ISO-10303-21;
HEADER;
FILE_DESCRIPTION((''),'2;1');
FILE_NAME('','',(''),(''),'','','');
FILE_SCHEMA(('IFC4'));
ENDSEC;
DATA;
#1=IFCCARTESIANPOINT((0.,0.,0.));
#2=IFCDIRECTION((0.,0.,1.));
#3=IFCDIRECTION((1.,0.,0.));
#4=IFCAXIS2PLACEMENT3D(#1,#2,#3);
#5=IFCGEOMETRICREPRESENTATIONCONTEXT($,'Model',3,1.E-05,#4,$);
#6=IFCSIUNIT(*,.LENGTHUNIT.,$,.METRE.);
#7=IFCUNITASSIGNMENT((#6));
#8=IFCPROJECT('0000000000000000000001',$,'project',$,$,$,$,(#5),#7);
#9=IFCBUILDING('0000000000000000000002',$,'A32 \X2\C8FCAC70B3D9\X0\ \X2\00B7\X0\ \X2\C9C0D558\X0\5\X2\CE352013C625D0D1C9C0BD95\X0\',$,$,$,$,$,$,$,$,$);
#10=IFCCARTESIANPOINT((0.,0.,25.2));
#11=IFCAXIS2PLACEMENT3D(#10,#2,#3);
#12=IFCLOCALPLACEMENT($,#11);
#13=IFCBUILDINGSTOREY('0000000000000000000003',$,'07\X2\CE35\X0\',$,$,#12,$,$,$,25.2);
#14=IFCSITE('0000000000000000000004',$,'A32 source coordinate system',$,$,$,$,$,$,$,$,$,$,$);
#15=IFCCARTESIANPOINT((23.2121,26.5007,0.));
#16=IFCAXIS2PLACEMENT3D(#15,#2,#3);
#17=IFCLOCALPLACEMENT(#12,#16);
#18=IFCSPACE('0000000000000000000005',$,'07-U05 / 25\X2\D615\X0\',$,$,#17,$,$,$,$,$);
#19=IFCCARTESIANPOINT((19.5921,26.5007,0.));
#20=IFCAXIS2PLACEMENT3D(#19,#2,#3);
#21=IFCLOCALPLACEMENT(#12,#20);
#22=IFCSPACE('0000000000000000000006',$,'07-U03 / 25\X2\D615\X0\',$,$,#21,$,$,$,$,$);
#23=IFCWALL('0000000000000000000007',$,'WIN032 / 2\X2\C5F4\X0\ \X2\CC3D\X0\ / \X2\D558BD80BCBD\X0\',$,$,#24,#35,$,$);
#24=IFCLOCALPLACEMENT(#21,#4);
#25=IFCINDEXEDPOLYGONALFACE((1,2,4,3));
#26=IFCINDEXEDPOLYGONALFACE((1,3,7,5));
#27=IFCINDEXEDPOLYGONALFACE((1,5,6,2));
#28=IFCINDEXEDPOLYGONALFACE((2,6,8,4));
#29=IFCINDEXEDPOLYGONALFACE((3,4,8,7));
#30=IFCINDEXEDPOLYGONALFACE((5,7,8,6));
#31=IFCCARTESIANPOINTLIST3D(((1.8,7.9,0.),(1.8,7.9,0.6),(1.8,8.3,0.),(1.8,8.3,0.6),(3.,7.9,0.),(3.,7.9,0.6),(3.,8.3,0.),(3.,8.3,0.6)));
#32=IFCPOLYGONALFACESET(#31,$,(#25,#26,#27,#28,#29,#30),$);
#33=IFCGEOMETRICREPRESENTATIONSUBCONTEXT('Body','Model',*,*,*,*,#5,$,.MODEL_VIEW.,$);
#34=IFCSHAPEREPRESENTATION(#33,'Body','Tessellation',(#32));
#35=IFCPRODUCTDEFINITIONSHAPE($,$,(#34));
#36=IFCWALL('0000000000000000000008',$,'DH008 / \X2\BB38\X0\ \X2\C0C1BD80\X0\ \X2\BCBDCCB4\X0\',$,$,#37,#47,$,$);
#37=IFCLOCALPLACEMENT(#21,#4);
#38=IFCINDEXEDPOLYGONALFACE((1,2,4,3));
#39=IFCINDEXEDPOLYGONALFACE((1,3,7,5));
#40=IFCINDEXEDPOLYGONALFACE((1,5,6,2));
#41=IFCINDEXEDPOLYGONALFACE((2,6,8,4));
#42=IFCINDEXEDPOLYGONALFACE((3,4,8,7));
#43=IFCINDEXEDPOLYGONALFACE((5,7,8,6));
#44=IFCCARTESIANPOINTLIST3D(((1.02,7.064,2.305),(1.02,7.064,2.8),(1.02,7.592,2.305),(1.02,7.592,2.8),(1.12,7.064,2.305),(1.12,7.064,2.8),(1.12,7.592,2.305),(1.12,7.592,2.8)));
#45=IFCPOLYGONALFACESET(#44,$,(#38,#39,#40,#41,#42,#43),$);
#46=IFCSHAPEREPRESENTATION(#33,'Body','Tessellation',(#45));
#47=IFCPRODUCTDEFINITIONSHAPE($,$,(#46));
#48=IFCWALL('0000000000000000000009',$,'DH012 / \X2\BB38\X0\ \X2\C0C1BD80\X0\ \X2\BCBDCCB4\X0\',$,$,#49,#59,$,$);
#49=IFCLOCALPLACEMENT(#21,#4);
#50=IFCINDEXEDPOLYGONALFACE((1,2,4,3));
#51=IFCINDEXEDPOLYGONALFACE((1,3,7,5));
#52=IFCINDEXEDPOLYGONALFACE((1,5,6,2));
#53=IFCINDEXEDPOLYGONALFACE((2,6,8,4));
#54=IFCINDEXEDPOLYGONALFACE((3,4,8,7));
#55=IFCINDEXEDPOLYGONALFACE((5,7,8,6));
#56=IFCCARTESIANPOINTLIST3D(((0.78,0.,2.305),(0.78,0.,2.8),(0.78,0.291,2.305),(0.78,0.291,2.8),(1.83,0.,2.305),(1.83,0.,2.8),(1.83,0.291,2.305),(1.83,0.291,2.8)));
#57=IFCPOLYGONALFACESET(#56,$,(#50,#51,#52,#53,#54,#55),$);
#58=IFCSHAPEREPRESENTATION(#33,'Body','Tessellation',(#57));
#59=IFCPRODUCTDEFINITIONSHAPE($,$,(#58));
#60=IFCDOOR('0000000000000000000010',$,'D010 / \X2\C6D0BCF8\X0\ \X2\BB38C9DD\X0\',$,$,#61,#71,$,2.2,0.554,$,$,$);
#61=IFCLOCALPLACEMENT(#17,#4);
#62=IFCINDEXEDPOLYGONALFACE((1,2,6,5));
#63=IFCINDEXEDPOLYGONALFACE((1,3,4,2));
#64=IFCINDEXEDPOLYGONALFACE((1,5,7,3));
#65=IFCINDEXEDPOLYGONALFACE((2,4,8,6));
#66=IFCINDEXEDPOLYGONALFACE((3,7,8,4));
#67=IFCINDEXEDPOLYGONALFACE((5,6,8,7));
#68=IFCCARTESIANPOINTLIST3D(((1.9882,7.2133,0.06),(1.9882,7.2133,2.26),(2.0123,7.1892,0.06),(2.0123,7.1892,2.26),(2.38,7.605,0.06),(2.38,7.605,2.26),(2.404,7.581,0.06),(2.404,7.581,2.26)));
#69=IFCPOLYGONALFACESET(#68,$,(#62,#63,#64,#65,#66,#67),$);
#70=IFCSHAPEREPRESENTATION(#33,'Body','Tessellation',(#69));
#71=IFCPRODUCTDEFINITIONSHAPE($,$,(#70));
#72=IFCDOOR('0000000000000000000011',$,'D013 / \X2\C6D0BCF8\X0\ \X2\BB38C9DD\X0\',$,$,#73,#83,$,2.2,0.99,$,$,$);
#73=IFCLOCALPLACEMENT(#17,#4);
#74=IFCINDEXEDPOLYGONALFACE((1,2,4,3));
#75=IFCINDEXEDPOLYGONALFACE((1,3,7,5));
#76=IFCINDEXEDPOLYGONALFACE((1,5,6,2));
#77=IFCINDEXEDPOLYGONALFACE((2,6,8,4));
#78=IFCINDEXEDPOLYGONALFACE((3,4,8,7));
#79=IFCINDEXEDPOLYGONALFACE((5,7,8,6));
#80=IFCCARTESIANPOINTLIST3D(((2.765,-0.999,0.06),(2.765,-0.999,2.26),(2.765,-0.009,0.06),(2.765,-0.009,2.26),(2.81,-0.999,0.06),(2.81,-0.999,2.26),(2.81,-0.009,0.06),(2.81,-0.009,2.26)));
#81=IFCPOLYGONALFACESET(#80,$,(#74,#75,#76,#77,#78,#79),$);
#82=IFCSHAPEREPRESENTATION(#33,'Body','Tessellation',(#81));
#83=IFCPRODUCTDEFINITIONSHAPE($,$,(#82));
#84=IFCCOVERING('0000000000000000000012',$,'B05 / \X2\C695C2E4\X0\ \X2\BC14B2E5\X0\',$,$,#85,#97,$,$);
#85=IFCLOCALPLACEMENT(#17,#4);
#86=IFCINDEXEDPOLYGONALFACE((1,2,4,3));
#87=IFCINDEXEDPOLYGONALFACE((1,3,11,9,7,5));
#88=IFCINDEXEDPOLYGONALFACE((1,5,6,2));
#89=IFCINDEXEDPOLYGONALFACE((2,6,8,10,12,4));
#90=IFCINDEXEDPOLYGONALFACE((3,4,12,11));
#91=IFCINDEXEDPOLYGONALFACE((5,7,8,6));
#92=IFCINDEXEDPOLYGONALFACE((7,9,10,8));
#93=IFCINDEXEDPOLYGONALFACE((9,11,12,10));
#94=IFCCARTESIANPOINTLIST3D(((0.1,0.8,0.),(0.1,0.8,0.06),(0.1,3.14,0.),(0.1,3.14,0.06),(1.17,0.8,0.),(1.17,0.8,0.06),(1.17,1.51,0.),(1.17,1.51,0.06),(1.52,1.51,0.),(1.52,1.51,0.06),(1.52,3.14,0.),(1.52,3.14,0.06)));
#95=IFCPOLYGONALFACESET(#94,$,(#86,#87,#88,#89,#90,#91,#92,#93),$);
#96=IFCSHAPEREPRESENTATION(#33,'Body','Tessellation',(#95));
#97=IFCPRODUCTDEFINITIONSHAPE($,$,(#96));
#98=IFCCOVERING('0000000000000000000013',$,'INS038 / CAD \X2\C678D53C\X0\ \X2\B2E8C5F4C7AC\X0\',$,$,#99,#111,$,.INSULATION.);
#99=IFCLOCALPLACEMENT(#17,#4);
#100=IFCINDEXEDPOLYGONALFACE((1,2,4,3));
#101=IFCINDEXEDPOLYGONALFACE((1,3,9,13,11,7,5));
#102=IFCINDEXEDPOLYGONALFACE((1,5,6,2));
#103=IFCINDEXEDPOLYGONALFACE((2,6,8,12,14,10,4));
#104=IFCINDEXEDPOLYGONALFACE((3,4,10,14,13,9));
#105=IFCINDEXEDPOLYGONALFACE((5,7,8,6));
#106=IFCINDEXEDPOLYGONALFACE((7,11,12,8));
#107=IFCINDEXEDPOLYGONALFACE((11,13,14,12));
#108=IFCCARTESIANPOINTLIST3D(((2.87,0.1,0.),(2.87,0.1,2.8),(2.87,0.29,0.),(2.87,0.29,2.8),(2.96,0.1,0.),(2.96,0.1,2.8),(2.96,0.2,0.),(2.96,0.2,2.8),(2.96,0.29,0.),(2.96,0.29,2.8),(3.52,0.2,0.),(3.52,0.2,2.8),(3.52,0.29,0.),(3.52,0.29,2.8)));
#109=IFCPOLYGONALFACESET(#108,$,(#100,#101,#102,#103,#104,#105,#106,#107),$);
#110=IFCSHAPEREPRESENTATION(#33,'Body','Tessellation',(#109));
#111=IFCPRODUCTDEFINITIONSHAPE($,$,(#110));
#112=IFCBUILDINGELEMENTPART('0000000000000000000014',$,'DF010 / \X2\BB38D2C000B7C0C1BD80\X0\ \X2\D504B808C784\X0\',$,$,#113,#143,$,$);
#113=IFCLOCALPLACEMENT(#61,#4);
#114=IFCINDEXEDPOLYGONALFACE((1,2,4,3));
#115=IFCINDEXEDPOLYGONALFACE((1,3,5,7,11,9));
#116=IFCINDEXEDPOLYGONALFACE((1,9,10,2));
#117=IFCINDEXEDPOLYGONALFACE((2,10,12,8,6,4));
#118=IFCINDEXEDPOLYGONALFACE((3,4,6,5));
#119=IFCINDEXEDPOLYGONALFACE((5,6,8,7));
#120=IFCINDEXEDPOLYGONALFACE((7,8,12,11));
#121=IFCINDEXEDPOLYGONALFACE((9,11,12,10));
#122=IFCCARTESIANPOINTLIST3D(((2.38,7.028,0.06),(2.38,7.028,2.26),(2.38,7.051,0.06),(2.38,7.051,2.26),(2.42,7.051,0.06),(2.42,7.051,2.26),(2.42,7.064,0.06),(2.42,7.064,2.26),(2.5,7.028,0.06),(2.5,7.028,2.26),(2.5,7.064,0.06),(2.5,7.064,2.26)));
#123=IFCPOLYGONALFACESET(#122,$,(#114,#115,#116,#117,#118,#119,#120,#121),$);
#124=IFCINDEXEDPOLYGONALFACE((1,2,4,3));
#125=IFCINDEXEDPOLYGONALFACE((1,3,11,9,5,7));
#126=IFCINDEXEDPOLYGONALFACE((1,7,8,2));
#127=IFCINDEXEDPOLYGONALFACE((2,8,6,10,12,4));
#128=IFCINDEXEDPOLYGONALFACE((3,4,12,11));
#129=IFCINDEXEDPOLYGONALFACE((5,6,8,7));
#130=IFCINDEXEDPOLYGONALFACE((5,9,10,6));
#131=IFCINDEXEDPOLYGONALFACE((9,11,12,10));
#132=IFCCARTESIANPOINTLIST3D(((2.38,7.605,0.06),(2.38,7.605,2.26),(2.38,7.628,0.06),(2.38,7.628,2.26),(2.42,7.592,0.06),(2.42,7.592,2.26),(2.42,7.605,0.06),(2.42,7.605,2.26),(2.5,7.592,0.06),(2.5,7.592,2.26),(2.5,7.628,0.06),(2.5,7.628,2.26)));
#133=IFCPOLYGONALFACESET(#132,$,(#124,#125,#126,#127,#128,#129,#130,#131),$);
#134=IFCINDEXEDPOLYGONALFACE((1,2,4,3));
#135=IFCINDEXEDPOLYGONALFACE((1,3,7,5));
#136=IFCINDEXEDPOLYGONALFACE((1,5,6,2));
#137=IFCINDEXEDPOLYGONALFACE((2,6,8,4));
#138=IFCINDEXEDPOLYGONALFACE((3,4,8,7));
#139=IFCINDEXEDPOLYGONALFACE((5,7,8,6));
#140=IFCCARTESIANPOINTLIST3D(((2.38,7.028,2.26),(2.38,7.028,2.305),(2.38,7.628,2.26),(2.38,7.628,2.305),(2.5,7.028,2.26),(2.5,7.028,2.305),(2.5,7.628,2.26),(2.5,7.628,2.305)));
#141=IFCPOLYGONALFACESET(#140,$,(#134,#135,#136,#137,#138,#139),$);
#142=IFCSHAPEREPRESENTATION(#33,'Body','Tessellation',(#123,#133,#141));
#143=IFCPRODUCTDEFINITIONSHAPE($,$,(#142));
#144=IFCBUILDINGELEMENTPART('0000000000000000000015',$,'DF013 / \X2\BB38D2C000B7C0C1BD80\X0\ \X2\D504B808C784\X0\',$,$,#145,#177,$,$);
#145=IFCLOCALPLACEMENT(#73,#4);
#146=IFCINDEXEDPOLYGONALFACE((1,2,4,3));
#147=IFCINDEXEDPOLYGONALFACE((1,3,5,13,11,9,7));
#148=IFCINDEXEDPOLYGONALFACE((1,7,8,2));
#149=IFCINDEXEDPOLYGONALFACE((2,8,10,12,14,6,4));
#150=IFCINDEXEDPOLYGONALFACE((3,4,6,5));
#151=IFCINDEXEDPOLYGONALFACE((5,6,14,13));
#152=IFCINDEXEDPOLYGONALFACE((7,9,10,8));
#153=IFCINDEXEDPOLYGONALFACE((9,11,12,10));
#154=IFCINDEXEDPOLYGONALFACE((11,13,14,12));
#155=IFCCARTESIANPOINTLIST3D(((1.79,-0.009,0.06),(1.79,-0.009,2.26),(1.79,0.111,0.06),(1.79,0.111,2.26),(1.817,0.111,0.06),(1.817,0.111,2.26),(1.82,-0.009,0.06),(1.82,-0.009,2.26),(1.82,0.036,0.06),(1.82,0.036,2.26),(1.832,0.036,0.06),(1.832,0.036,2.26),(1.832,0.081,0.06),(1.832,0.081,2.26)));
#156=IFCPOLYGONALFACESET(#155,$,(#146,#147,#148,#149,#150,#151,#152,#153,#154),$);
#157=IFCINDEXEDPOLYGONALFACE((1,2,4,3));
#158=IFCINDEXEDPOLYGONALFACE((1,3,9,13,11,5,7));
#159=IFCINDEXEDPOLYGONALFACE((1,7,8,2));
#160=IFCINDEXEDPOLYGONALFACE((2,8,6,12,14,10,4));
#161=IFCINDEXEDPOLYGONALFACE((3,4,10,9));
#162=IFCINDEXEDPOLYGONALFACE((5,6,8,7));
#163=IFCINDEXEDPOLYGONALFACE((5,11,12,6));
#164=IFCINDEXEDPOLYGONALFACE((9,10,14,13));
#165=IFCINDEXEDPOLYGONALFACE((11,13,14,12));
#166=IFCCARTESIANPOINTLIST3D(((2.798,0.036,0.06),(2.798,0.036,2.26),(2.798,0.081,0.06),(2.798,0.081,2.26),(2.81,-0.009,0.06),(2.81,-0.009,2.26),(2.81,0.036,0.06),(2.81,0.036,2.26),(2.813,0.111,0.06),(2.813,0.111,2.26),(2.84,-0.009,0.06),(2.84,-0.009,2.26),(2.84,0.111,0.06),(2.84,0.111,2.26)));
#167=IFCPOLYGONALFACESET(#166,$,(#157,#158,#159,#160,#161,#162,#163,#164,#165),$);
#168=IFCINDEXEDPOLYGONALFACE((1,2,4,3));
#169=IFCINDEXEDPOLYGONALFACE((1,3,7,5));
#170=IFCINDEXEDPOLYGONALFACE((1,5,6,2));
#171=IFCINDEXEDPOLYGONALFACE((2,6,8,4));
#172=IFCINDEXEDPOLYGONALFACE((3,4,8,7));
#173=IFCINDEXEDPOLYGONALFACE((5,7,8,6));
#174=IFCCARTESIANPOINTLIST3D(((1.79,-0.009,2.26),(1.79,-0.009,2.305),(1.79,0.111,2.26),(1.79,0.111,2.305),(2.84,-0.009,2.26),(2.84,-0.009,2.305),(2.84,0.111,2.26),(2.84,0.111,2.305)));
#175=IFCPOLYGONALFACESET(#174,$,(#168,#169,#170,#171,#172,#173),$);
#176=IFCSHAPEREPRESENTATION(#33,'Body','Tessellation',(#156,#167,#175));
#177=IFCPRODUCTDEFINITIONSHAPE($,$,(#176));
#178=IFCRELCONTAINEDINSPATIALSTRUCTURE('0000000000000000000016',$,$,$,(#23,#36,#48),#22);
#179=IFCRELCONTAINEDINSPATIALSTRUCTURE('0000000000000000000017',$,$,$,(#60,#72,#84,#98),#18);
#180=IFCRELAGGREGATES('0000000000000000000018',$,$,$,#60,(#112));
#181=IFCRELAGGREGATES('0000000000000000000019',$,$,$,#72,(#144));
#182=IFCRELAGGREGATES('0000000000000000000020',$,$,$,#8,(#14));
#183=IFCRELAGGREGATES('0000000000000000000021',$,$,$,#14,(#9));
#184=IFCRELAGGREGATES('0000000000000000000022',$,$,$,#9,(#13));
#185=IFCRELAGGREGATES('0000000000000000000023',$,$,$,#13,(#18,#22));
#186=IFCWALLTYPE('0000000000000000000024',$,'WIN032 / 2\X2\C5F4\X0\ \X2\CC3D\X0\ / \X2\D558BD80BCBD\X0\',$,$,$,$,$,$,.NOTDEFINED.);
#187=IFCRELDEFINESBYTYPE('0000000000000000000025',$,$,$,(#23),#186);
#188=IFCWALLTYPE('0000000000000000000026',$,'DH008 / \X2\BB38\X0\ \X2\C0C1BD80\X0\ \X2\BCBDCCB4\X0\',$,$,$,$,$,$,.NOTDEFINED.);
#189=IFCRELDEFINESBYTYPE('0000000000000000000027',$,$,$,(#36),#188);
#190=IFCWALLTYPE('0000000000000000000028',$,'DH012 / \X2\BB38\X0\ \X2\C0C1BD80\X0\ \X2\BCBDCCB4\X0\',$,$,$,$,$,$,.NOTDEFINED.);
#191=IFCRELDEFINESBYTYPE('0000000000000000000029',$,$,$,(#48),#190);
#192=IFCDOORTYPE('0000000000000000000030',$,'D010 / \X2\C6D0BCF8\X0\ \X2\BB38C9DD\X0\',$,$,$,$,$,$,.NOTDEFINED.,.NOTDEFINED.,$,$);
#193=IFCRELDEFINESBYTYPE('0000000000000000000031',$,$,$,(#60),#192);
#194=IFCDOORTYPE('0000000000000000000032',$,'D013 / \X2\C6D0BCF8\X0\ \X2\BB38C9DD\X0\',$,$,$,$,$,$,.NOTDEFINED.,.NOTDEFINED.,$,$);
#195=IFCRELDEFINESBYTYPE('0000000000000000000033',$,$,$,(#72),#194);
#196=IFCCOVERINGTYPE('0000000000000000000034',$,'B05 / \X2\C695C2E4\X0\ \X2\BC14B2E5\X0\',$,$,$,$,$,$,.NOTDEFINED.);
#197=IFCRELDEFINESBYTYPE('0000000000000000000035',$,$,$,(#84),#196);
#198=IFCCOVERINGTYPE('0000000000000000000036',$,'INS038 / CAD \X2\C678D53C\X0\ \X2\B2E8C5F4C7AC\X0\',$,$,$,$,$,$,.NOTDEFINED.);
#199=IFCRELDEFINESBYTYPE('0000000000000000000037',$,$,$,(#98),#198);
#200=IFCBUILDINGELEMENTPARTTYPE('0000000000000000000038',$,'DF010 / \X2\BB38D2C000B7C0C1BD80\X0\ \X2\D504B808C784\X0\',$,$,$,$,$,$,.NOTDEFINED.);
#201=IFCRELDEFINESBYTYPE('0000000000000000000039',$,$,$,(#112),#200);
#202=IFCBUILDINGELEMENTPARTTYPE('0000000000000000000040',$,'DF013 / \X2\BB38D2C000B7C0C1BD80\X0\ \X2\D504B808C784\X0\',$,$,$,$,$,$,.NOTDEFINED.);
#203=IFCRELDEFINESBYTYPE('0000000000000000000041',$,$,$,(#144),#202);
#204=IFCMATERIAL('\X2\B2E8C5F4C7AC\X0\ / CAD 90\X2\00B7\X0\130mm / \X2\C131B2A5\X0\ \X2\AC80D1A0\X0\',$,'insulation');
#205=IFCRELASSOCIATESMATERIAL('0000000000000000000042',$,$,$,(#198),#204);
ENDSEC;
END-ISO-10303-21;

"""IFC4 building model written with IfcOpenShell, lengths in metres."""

from ifc_helpers import new_model, si_unit, frame, origin, origin_with_axes, place, context, subcontext, project, spatial, polyline, outline, extrude, source, transform, mapped, material, type_object, type_shapes, element, aggregate, save


model = new_model("IFC4")

# Units and contexts
model_context = context("Model", 3, precision=1e-05, world=origin_with_axes())
body_context = subcontext(model_context, "Body", "Model", "MODEL_VIEW")
ifc_project = project(units=[si_unit("LENGTHUNIT", "METRE")], contexts=[model_context])

# Site, building, storey, space
storey_placement = place(None, frame((0.0, 0.0, 25.2), z_axis=(0.0, 0.0, 1.0), x_axis=(1.0, 0.0, 0.0)))
space_1_placement = place(storey_placement, frame((23.2121, 26.5007, 0.0), z_axis=(0.0, 0.0, 1.0), x_axis=(1.0, 0.0, 0.0)))
site = spatial("IfcSite", under=ifc_project, Name="A32 source coordinate system")
building = spatial("IfcBuilding", under=site, Name="A32 주거동 · 지하5층–옥탑지붕")
storey = spatial("IfcBuildingStorey", under=building, at=storey_placement, Name="07층", Elevation=25.2)
space_1 = spatial("IfcSpace", under=storey, at=space_1_placement, Name="07-U05 / 25형")

# Shared definitions
space_2_placement = place(storey_placement, frame((19.5921, 26.5007, 0.0), z_axis=(0.0, 0.0, 1.0), x_axis=(1.0, 0.0, 0.0)))
space_2 = spatial("IfcSpace", under=storey, at=space_2_placement, Name="07-U03 / 25형")

# Walls
wall_type_1 = type_object("IfcWallType", Name="WIN032 / 2열 창 / 하부벽", PredefinedType="NOTDEFINED")
shared_shape_1 = source(origin(), body_context, "Body", "SweptSolid", [
    extrude(outline(polyline([(3.0, 7.9), (1.8, 7.9), (1.8, 8.3), (3.0, 8.3), (3.0, 7.9)])), origin(), (0.0, 0.0, 1.0), 0.6),
])
type_shapes(wall_type_1, [shared_shape_1])
wall_1_placement = place(space_2_placement, origin_with_axes())
element("IfcWall", 1, at=wall_1_placement, inside=space_2, type_object=wall_type_1, Name="WIN032 / 2열 창 / 하부벽", context=body_context, shape_type="MappedRepresentation", body=[
    mapped(shared_shape_1, transform((0.0, 0.0, 0.0), scale=1.0)),
])
wall_type_2 = type_object("IfcWallType", Name="DH008 / 문 상부 벽체", PredefinedType="NOTDEFINED")
shared_shape_2 = source(origin(), body_context, "Body", "SweptSolid", [
    extrude(outline(polyline([(1.12, 7.064), (1.02, 7.064), (1.02, 7.592), (1.12, 7.592), (1.12, 7.064)])), frame((0.0, 0.0, 2.305)), (0.0, 0.0, 1.0), 0.495),
])
type_shapes(wall_type_2, [shared_shape_2])
wall_2_placement = place(space_2_placement, origin_with_axes())
element("IfcWall", 2, at=wall_2_placement, inside=space_2, type_object=wall_type_2, Name="DH008 / 문 상부 벽체", context=body_context, shape_type="MappedRepresentation", body=[
    mapped(shared_shape_2, transform((0.0, 0.0, 0.0), scale=1.0)),
])
wall_type_3 = type_object("IfcWallType", Name="DH012 / 문 상부 벽체", PredefinedType="NOTDEFINED")
shared_shape_3 = source(origin(), body_context, "Body", "SweptSolid", [
    extrude(outline(polyline([(0.78, 0.0), (0.78, 0.291), (1.83, 0.291), (1.83, 0.0), (0.78, 0.0)])), frame((0.0, 0.0, 2.305)), (0.0, 0.0, 1.0), 0.495),
])
type_shapes(wall_type_3, [shared_shape_3])
wall_3_placement = place(space_2_placement, origin_with_axes())
element("IfcWall", 3, at=wall_3_placement, inside=space_2, type_object=wall_type_3, Name="DH012 / 문 상부 벽체", context=body_context, shape_type="MappedRepresentation", body=[
    mapped(shared_shape_3, transform((0.0, 0.0, 0.0), scale=1.0)),
])

# Doors
door_type_1 = type_object("IfcDoorType", Name="D010 / 원본 문짝", OperationType="NOTDEFINED", PredefinedType="NOTDEFINED")
shared_shape_4 = source(origin(), body_context, "Body", "SweptSolid", [
    extrude(outline(polyline([(2.0123, 7.1892), (1.9882, 7.2133), (2.38, 7.605), (2.404, 7.581), (2.0123, 7.1892)])), frame((0.0, 0.0, 0.06)), (0.0, 0.0, 1.0), 2.2),
])
type_shapes(door_type_1, [shared_shape_4])
door_1_placement = place(space_1_placement, origin_with_axes())
door_1 = element("IfcDoor", 4, at=door_1_placement, inside=space_1, type_object=door_type_1, Name="D010 / 원본 문짝", OverallHeight=2.2, OverallWidth=0.554, context=body_context, shape_type="MappedRepresentation", body=[
    mapped(shared_shape_4, transform((0.0, 0.0, 0.0), scale=1.0)),
])
door_type_2 = type_object("IfcDoorType", Name="D013 / 원본 문짝", OperationType="NOTDEFINED", PredefinedType="NOTDEFINED")
shared_shape_5 = source(origin(), body_context, "Body", "SweptSolid", [
    extrude(outline(polyline([(2.81, -0.009), (2.81, -0.999), (2.765, -0.999), (2.765, -0.009), (2.81, -0.009)])), frame((0.0, 0.0, 0.06)), (0.0, 0.0, 1.0), 2.2),
])
type_shapes(door_type_2, [shared_shape_5])
door_2_placement = place(space_1_placement, origin_with_axes())
door_2 = element("IfcDoor", 5, at=door_2_placement, inside=space_1, type_object=door_type_2, Name="D013 / 원본 문짝", OverallHeight=2.2, OverallWidth=0.99, context=body_context, shape_type="MappedRepresentation", body=[
    mapped(shared_shape_5, transform((0.0, 0.0, 0.0), scale=1.0)),
])

# Coverings
covering_type_1 = type_object("IfcCoveringType", Name="B05 / 욕실 바닥", PredefinedType="NOTDEFINED")
shared_shape_6 = source(origin(), body_context, "Body", "SweptSolid", [
    extrude(outline(polyline([(0.1, 3.14), (1.52, 3.14), (1.52, 1.51), (1.17, 1.51), (1.17, 0.8), (0.1, 0.8), (0.1, 3.14)])), origin(), (0.0, 0.0, 1.0), 0.06),
])
type_shapes(covering_type_1, [shared_shape_6])
covering_1_placement = place(space_1_placement, origin_with_axes())
element("IfcCovering", 6, at=covering_1_placement, inside=space_1, type_object=covering_type_1, Name="B05 / 욕실 바닥", context=body_context, shape_type="MappedRepresentation", body=[
    mapped(shared_shape_6, transform((0.0, 0.0, 0.0), scale=1.0)),
])
ifc_material = material(Name="단열재 / CAD 90·130mm / 성능 검토", Category="insulation")
covering_type_2 = type_object("IfcCoveringType", Name="INS038 / CAD 외피 단열재", PredefinedType="NOTDEFINED", material=ifc_material)
shared_shape_7 = source(origin(), body_context, "Body", "SweptSolid", [
    extrude(outline(polyline([(2.96, 0.2), (2.96, 0.1), (2.87, 0.1), (2.87, 0.29), (2.96, 0.29), (3.52, 0.29), (3.52, 0.2), (2.96, 0.2)])), origin(), (0.0, 0.0, 1.0), 2.8),
])
type_shapes(covering_type_2, [shared_shape_7])
covering_2_placement = place(space_1_placement, origin_with_axes())
element("IfcCovering", 7, at=covering_2_placement, inside=space_1, type_object=covering_type_2, Name="INS038 / CAD 외피 단열재", PredefinedType="INSULATION", context=body_context, shape_type="MappedRepresentation", body=[
    mapped(shared_shape_7, transform((0.0, 0.0, 0.0), scale=1.0)),
])

# Building element parts
building_element_part_type_1 = type_object("IfcBuildingElementPartType", Name="DF010 / 문틀·상부 프레임", PredefinedType="NOTDEFINED")
shared_shape_8 = source(origin(), body_context, "Body", "SweptSolid", [
    extrude(outline(polyline([(2.38, 7.028), (2.38, 7.051), (2.42, 7.051), (2.42, 7.064), (2.5, 7.064), (2.5, 7.028), (2.38, 7.028)])), frame((0.0, 0.0, 0.06)), (0.0, 0.0, 1.0), 2.2),
    extrude(outline(polyline([(2.5, 7.592), (2.42, 7.592), (2.42, 7.605), (2.38, 7.605), (2.38, 7.628), (2.5, 7.628), (2.5, 7.592)])), frame((0.0, 0.0, 0.06)), (0.0, 0.0, 1.0), 2.2),
    extrude(outline(polyline([(2.38, 7.028), (2.38, 7.628), (2.5, 7.628), (2.5, 7.028), (2.38, 7.028)])), frame((0.0, 0.0, 2.26)), (0.0, 0.0, 1.0), 0.045),
])
type_shapes(building_element_part_type_1, [shared_shape_8])
building_element_part_1_placement = place(door_1_placement, origin_with_axes())
building_element_part_1 = element("IfcBuildingElementPart", 8, at=building_element_part_1_placement, type_object=building_element_part_type_1, Name="DF010 / 문틀·상부 프레임", context=body_context, shape_type="MappedRepresentation", body=[
    mapped(shared_shape_8, transform((0.0, 0.0, 0.0), scale=1.0)),
])
aggregate(door_1, [building_element_part_1])
building_element_part_type_2 = type_object("IfcBuildingElementPartType", Name="DF013 / 문틀·상부 프레임", PredefinedType="NOTDEFINED")
shared_shape_9 = source(origin(), body_context, "Body", "SweptSolid", [
    extrude(outline(polyline([(1.79, 0.111), (1.817, 0.111), (1.832, 0.081), (1.832, 0.036), (1.82, 0.036), (1.82, -0.009), (1.79, -0.009), (1.79, 0.111)])), frame((0.0, 0.0, 0.06)), (0.0, 0.0, 1.0), 2.2),
    extrude(outline(polyline([(2.81, -0.009), (2.81, 0.036), (2.798, 0.036), (2.798, 0.081), (2.813, 0.111), (2.84, 0.111), (2.84, -0.009), (2.81, -0.009)])), frame((0.0, 0.0, 0.06)), (0.0, 0.0, 1.0), 2.2),
    extrude(outline(polyline([(1.79, -0.009), (1.79, 0.111), (2.84, 0.111), (2.84, -0.009), (1.79, -0.009)])), frame((0.0, 0.0, 2.26)), (0.0, 0.0, 1.0), 0.045),
])
type_shapes(building_element_part_type_2, [shared_shape_9])
building_element_part_2_placement = place(door_2_placement, origin_with_axes())
building_element_part_2 = element("IfcBuildingElementPart", 9, at=building_element_part_2_placement, type_object=building_element_part_type_2, Name="DF013 / 문틀·상부 프레임", context=body_context, shape_type="MappedRepresentation", body=[
    mapped(shared_shape_9, transform((0.0, 0.0, 0.0), scale=1.0)),
])
aggregate(door_2, [building_element_part_2])

save(model, "model.ifc")
